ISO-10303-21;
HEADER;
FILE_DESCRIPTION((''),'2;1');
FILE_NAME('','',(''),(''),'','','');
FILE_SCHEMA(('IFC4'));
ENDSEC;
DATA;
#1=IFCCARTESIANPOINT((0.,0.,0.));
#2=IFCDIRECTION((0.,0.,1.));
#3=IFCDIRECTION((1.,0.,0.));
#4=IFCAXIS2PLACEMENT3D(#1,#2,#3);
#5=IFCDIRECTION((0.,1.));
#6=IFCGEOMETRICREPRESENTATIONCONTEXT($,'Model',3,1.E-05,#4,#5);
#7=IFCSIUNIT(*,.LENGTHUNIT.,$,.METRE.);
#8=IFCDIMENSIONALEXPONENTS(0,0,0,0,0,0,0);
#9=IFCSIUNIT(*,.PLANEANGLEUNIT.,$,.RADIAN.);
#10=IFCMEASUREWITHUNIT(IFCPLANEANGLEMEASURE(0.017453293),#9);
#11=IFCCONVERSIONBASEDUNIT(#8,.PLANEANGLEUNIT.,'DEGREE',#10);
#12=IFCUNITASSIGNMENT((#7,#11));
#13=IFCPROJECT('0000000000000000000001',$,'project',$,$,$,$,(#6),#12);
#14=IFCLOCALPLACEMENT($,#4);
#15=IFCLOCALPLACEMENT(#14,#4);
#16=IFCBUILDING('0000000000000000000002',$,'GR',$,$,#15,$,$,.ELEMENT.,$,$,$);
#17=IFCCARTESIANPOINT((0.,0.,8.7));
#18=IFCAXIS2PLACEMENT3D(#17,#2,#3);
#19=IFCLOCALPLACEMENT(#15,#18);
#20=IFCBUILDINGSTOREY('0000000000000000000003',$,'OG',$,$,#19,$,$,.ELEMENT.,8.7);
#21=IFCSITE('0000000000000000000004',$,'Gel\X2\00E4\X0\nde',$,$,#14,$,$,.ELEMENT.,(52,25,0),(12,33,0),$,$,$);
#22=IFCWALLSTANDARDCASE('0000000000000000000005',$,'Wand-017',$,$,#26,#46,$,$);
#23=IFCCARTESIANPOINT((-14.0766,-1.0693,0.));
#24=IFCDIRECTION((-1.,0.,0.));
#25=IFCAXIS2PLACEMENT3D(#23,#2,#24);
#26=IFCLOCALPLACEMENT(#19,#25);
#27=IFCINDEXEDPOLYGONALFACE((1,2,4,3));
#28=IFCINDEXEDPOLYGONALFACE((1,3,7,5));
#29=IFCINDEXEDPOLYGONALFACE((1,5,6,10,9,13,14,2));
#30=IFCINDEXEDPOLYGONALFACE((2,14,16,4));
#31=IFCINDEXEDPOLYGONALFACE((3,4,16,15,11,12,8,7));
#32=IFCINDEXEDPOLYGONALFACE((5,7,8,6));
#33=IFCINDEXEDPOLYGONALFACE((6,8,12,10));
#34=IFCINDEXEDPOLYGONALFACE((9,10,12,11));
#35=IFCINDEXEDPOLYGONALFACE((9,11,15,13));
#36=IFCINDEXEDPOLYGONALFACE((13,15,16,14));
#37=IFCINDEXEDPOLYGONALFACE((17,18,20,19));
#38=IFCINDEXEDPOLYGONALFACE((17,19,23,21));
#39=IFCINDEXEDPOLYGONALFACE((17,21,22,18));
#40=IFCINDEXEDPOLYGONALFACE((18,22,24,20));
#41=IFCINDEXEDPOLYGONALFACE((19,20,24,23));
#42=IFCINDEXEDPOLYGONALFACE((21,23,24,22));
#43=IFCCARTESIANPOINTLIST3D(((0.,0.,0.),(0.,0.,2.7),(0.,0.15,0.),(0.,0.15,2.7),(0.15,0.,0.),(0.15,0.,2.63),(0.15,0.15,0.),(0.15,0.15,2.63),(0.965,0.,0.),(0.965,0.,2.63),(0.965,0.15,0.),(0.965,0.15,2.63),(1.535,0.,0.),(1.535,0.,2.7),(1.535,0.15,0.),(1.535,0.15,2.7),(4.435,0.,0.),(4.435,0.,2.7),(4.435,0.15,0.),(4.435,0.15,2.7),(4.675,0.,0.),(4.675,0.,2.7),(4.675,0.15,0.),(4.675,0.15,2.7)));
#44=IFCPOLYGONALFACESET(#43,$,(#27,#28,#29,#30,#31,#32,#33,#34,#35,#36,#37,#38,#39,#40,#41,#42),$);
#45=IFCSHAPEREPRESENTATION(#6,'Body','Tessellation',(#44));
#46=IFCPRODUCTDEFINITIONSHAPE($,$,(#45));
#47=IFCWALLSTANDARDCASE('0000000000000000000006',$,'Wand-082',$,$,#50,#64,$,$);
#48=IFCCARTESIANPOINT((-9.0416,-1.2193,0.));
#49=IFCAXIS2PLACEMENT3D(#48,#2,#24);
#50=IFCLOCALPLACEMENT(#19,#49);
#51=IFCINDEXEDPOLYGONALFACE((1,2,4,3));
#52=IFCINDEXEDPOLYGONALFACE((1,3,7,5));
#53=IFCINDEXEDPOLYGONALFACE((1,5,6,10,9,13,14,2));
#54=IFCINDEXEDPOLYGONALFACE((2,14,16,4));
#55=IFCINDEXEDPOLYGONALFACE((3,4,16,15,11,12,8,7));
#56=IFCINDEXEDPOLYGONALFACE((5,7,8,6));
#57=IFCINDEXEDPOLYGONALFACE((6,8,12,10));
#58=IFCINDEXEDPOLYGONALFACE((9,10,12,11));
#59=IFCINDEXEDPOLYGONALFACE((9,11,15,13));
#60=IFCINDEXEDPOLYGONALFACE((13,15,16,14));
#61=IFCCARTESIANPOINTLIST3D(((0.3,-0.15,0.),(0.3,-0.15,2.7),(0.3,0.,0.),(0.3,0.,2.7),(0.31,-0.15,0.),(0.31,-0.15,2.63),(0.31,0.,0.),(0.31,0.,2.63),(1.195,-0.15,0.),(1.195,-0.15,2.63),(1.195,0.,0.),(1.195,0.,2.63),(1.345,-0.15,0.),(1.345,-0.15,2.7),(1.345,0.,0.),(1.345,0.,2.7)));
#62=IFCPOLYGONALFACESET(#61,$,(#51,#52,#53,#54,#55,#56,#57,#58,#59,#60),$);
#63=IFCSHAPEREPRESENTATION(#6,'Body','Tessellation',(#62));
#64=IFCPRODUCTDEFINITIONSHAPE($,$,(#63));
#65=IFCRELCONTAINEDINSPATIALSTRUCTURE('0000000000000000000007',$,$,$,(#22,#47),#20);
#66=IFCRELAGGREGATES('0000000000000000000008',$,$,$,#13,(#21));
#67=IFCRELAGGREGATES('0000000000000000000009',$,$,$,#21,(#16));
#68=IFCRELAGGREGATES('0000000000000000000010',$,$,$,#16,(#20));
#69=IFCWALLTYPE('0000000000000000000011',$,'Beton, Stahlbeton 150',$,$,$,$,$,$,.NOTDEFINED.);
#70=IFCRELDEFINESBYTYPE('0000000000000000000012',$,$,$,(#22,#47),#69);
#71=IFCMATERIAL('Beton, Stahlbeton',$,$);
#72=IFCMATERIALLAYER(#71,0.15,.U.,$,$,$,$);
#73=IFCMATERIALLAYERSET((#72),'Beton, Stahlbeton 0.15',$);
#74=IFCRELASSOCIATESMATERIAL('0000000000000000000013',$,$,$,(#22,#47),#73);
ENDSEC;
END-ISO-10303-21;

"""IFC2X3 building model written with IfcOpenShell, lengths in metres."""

from ifc_helpers import new_model, entity, si_unit, converted_unit, direction, frame, origin_with_axes, origin_2d_with_axis, place, context, project, spatial, polyline, rectangle, outline, extrude, material, layer, layer_set, layer_usage, type_object, element, save


model = new_model("IFC2X3")

# Units and contexts
model_context = context("Model", 3, precision=1e-05, world=origin_with_axes(), true_north=direction((0.0, 1.0)))
ifc_project = project(units=[si_unit("LENGTHUNIT", "METRE"), converted_unit("PLANEANGLEUNIT", "DEGREE", entity("IfcPlaneAngleMeasure", 0.017453293), si_unit("PLANEANGLEUNIT", "RADIAN"), dimensions=[0, 0, 0, 0, 0, 0, 0])], contexts=[model_context])

# Site, building, storey
site_placement = place(None, origin_with_axes())
site = spatial("IfcSite", under=ifc_project, at=site_placement, Name="Gelände", CompositionType="ELEMENT", RefLatitude=(52, 25, 0), RefLongitude=(12, 33, 0))
building_placement = place(site_placement, origin_with_axes())
building = spatial("IfcBuilding", under=site, at=building_placement, Name="GR", CompositionType="ELEMENT")
storey_placement = place(building_placement, frame((0.0, 0.0, 8.7), z_axis=(0.0, 0.0, 1.0), x_axis=(1.0, 0.0, 0.0)))
storey = spatial("IfcBuildingStorey", under=building, at=storey_placement, Name="OG", CompositionType="ELEMENT", Elevation=8.7)

# Shared definitions
ifc_material_1 = material(Name="Beton, Stahlbeton")

# Wall, openings
ifc_layer_1 = layer(ifc_material_1, 0.15, ventilated="UNKNOWN")
ifc_layer_set_1 = layer_set([ifc_layer_1], Name="Beton, Stahlbeton 0.15")
ifc_layer_usage_1 = layer_usage(ifc_layer_set_1, "AXIS2", "POSITIVE", 0.0)
wall_type_1 = type_object("IfcWallType", Name="Beton, Stahlbeton 150", PredefinedType="NOTDEFINED")
wall_1_placement = place(storey_placement, frame((-14.0766, -1.0693, 0.0), z_axis=(0.0, 0.0, 1.0), x_axis=(-1.0, 0.0, 0.0)))
wall_1 = element("IfcWallStandardCase", 1, at=wall_1_placement, inside=storey, type_object=wall_type_1, material=ifc_layer_usage_1, Name="Wand-017", context=model_context, shape_type="SweptSolid", body=[
    extrude(outline(polyline([(0.0, 0.0), (4.675, 0.0), (4.675, 0.15), (0.0, 0.15), (0.0, 0.0)])), origin_with_axes(), (0.0, 0.0, 1.0), 2.7),
])
opening_1_placement = place(wall_1_placement, frame((2.985, 0.0, 0.0), z_axis=(0.0, 0.0, 1.0), x_axis=(1.0, 0.0, 0.0)))
element("IfcOpeningElement", 2, at=opening_1_placement, cuts=wall_1, context=model_context, shape_type="SweptSolid", body=[
    extrude(rectangle(XDim=2.9, YDim=2.7, at=origin_2d_with_axis()), frame((0.0, -0.001, 1.35), z_axis=(0.0, 1.0, 0.0), x_axis=(1.0, 0.0, 0.0)), (0.0, 0.0, 1.0), 0.452),
])
opening_2_placement = place(wall_1_placement, frame((0.5575, 0.0, 0.0), z_axis=(0.0, 0.0, 1.0), x_axis=(1.0, 0.0, 0.0)))
element("IfcOpeningElement", 3, at=opening_2_placement, cuts=wall_1, context=model_context, shape_type="SweptSolid", body=[
    extrude(rectangle(XDim=0.815, YDim=2.63, at=origin_2d_with_axis()), frame((0.0, 0.151, 1.315), z_axis=(0.0, -1.0, 0.0), x_axis=(1.0, 0.0, 0.0)), (0.0, 0.0, 1.0), 0.452),
])

# Wall, opening
ifc_layer_usage_2 = layer_usage(ifc_layer_set_1, "AXIS2", "NEGATIVE", 0.0)
wall_2_placement = place(storey_placement, frame((-9.0416, -1.2193, 0.0), z_axis=(0.0, 0.0, 1.0), x_axis=(-1.0, 0.0, 0.0)))
wall_2 = element("IfcWallStandardCase", 4, at=wall_2_placement, inside=storey, type_object=wall_type_1, material=ifc_layer_usage_2, Name="Wand-082", context=model_context, shape_type="SweptSolid", body=[
    extrude(outline(polyline([(0.3, -0.15), (1.345, -0.15), (1.345, 0.0), (0.3, 0.0), (0.3, -0.15)])), origin_with_axes(), (0.0, 0.0, 1.0), 2.7),
])
opening_3_placement = place(wall_2_placement, frame((0.7525, 0.0, 0.0), z_axis=(0.0, 0.0, 1.0), x_axis=(1.0, 0.0, 0.0)))
element("IfcOpeningElement", 5, at=opening_3_placement, cuts=wall_2, context=model_context, shape_type="SweptSolid", body=[
    extrude(rectangle(XDim=0.885, YDim=2.63, at=origin_2d_with_axis()), frame((0.0, -0.151, 1.315), z_axis=(0.0, 1.0, 0.0), x_axis=(1.0, 0.0, 0.0)), (0.0, 0.0, 1.0), 0.452),
])

save(model, "model.ifc")
